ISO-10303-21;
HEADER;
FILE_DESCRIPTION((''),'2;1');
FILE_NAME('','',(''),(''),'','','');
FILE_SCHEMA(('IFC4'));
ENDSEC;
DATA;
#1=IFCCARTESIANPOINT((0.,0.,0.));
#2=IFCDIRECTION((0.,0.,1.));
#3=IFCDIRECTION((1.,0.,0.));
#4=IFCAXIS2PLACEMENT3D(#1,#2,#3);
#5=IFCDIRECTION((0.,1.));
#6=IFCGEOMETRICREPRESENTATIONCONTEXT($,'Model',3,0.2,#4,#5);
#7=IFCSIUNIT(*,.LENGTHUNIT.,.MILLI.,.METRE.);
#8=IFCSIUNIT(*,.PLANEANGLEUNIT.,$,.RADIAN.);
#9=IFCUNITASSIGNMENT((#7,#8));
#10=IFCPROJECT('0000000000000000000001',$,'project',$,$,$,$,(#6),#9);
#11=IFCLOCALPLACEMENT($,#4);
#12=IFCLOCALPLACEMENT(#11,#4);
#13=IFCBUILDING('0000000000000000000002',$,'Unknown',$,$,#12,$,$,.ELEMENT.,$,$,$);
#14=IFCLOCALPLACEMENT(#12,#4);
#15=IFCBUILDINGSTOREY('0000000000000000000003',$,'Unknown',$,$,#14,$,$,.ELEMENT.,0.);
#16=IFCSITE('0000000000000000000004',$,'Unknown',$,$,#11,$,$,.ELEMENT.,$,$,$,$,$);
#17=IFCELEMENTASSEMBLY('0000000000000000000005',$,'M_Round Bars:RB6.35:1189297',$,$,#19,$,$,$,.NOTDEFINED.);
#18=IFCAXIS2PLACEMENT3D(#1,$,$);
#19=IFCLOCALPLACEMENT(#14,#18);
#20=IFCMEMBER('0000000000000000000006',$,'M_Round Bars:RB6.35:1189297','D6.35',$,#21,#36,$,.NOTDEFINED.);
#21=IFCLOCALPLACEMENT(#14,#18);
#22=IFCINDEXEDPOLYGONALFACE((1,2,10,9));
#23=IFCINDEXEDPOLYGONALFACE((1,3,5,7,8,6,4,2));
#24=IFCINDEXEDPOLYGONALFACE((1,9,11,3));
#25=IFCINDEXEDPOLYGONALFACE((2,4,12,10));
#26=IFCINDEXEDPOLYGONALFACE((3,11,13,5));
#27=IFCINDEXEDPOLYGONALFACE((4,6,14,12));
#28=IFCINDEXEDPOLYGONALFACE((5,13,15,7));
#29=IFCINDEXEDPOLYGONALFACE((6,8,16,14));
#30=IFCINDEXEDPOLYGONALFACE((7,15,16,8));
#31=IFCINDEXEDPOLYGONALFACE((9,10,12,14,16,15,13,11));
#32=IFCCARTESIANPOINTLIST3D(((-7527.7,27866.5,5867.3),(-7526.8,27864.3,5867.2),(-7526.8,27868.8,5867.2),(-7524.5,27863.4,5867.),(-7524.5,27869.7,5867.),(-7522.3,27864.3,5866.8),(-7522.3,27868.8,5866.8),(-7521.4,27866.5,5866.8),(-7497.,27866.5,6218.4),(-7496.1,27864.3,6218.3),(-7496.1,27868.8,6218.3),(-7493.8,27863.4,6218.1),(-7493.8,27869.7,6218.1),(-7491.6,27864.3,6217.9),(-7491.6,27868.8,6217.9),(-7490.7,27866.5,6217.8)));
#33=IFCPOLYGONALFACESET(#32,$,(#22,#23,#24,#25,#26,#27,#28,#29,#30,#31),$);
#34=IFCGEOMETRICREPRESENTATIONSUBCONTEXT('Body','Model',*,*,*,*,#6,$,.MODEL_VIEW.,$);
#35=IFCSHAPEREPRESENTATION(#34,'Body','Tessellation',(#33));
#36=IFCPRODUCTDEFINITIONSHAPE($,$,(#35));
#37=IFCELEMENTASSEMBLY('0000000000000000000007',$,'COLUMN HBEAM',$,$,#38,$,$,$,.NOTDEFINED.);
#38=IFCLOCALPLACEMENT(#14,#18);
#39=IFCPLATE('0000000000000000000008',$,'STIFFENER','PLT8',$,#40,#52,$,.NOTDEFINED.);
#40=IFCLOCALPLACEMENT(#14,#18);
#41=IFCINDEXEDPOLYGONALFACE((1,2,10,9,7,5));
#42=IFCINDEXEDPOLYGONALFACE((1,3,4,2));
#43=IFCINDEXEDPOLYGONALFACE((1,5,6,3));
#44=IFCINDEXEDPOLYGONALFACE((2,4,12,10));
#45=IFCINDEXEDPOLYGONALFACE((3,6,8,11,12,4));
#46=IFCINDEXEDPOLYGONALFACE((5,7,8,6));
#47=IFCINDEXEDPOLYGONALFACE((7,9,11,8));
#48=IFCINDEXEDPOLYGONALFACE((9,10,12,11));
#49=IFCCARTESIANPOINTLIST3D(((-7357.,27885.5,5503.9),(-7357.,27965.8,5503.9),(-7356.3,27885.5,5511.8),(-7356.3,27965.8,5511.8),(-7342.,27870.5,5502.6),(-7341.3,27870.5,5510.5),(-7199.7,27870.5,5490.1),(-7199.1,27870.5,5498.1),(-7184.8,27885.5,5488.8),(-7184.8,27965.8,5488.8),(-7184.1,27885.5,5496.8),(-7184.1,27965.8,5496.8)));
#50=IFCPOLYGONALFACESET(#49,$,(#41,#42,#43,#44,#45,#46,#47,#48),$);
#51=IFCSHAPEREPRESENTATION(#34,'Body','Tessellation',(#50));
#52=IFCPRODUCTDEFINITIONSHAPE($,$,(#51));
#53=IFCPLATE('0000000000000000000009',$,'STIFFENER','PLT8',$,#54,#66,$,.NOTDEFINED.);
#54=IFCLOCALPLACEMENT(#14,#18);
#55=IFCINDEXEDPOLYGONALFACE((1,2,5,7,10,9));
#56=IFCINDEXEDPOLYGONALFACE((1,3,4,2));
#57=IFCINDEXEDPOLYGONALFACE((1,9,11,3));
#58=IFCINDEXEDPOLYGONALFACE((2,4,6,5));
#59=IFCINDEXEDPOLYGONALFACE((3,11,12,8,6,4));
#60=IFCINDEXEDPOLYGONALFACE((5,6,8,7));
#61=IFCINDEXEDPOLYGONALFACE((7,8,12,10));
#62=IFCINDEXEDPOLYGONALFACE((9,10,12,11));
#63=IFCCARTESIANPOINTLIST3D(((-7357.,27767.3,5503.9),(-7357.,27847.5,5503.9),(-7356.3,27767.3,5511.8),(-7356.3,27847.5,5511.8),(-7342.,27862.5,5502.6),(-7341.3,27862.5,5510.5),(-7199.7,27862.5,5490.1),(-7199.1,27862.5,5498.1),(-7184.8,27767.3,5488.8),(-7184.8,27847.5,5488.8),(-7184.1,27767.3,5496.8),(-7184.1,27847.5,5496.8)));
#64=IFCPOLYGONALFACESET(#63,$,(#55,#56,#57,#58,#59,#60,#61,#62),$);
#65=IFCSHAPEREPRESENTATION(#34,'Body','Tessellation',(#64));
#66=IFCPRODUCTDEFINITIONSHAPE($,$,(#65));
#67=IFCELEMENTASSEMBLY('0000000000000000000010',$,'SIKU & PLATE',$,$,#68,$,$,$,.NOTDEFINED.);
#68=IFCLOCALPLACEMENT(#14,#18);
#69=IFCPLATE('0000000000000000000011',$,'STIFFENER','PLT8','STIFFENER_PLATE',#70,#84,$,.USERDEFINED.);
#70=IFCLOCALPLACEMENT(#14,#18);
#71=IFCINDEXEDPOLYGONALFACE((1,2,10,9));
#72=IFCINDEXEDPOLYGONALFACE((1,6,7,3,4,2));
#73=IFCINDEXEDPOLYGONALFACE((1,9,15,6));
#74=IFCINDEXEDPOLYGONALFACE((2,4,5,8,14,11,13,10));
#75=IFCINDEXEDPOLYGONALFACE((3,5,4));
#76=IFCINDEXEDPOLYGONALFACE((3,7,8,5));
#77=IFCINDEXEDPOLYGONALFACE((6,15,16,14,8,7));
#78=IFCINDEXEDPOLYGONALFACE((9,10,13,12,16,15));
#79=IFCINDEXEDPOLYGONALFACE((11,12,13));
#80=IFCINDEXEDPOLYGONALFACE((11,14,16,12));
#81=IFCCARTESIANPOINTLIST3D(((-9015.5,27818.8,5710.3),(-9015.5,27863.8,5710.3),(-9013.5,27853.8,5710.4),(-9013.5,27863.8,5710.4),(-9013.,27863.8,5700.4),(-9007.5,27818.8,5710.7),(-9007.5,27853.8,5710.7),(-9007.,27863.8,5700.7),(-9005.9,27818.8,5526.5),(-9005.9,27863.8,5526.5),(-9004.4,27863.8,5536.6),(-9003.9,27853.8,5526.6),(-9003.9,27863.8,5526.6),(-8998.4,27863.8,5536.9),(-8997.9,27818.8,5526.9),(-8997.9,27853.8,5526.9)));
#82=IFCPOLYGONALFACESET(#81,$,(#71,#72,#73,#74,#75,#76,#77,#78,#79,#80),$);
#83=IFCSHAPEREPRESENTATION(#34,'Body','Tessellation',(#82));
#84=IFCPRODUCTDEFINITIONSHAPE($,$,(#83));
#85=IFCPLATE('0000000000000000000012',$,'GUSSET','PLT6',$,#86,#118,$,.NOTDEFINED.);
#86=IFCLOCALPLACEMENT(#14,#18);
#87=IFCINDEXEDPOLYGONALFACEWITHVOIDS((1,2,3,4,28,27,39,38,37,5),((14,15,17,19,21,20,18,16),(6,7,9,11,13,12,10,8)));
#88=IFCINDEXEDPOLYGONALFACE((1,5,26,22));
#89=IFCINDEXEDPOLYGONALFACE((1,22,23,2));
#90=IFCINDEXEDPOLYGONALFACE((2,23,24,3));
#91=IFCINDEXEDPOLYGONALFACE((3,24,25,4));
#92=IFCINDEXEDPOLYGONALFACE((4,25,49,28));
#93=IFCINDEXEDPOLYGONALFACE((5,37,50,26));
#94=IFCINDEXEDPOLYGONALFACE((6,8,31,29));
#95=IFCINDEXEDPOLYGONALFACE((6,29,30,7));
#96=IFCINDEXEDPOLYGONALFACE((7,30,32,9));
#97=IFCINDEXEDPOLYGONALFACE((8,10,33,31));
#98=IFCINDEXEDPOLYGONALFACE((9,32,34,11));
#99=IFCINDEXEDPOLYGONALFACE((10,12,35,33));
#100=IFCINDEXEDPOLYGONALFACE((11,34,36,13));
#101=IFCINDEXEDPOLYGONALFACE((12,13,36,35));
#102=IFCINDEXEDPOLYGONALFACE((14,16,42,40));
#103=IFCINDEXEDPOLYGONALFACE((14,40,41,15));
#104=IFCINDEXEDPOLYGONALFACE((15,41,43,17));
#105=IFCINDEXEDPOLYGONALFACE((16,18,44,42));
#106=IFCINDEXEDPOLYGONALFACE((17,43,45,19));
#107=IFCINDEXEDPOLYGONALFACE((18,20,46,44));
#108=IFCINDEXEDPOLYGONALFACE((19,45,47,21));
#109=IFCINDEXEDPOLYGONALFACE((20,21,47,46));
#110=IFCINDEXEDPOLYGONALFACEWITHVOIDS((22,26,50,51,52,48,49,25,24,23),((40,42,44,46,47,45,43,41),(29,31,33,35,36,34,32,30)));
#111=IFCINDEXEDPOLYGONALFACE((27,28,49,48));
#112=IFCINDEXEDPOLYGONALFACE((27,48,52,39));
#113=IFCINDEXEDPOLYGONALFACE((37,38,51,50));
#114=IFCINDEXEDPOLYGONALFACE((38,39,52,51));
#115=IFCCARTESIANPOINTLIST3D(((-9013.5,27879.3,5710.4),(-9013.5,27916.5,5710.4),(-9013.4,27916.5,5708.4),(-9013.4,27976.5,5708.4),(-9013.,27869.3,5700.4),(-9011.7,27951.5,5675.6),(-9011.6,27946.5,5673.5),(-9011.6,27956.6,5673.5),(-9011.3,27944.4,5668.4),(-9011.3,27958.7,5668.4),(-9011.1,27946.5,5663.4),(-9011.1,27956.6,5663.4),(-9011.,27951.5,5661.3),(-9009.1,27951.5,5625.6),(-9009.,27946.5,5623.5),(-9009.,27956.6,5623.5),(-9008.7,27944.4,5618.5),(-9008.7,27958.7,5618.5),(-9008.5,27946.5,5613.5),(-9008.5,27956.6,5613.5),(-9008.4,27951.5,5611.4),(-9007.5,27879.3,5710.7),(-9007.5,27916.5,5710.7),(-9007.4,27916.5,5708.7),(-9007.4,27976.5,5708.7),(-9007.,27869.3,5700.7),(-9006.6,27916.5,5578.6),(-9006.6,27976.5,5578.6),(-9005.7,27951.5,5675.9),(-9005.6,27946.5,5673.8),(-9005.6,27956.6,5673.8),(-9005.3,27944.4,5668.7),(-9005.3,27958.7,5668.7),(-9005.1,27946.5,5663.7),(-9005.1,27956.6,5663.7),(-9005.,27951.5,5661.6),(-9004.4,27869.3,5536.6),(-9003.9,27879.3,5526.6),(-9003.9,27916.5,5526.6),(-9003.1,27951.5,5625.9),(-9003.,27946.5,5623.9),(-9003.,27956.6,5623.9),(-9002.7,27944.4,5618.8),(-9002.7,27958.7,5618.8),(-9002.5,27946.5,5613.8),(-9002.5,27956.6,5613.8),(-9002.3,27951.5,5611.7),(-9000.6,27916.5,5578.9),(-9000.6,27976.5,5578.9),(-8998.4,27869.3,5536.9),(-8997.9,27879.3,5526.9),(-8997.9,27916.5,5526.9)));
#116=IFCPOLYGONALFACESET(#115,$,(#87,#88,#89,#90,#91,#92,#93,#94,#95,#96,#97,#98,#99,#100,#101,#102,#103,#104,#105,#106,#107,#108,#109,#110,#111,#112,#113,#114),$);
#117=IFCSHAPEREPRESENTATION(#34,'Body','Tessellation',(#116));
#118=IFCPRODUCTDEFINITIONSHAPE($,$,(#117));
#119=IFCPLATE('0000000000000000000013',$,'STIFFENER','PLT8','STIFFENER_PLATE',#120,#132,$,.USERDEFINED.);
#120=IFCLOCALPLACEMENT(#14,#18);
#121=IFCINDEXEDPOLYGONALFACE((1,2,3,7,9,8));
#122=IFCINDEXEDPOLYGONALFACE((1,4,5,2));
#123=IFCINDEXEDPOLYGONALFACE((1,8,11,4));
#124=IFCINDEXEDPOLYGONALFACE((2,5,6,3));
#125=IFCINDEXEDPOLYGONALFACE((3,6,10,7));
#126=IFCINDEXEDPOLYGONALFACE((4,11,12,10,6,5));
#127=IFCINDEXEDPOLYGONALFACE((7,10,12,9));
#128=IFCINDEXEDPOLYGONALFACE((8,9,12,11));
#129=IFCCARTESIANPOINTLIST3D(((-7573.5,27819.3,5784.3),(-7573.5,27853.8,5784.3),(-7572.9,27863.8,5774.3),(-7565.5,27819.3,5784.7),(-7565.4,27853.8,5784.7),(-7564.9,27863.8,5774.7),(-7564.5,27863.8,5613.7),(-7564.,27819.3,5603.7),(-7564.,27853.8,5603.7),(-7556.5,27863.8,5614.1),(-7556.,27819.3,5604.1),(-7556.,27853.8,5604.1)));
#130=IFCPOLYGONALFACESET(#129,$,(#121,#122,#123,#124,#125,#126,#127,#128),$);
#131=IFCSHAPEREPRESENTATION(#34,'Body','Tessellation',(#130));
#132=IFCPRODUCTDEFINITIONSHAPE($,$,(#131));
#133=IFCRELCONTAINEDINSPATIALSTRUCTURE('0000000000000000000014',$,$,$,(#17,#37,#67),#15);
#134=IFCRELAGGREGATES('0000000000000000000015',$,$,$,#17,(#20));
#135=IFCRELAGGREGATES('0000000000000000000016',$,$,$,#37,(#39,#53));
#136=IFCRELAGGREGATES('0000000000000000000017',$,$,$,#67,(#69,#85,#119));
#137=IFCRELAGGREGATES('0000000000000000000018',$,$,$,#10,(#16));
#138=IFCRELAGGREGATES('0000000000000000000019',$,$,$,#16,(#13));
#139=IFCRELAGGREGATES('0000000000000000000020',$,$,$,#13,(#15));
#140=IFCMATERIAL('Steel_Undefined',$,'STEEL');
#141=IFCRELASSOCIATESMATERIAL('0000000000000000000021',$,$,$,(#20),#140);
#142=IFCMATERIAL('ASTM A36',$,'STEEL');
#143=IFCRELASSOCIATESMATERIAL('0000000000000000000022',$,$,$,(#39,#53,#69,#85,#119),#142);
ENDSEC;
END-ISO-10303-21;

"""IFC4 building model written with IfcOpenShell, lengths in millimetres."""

from ifc_helpers import new_model, si_unit, direction, frame, origin_with_axes, place, context, subcontext, project, spatial, line, indexed_curve, outline, extrude, material, element, aggregate, save


model = new_model("IFC4")

# Units and contexts
model_context = context("Model", 3, precision=0.2, world=origin_with_axes(), true_north=direction((0.0, 1.0)))
body_context = subcontext(model_context, "Body", "Model", "MODEL_VIEW")
ifc_project = project(units=[si_unit("LENGTHUNIT", "METRE", prefix="MILLI"), si_unit("PLANEANGLEUNIT", "RADIAN")], contexts=[model_context])

# Site, building, storey
site_placement = place(None, origin_with_axes())
site = spatial("IfcSite", under=ifc_project, at=site_placement, Name="Unknown", CompositionType="ELEMENT")
building_placement = place(site_placement, origin_with_axes())
building = spatial("IfcBuilding", under=site, at=building_placement, Name="Unknown", CompositionType="ELEMENT")
storey_placement = place(building_placement, origin_with_axes())
storey = spatial("IfcBuildingStorey", under=building, at=storey_placement, Name="Unknown", CompositionType="ELEMENT", Elevation=0.0)

# Element assembly, member
ifc_material_1 = material(Name="Steel_Undefined", Category="STEEL")
assembly_1_placement = place(storey_placement, frame((-7493.8, 27866.5, 6218.1), z_axis=(-0.000002, -1.0, 0.0), x_axis=(-0.087153, 0.0, -0.996195)))
assembly_1 = element("IfcElementAssembly", 1, at=assembly_1_placement, inside=storey, Name="M_Round Bars:RB6.35:1189297", PredefinedType="NOTDEFINED")
member_1_placement = place(assembly_1_placement, origin_with_axes())
member_1 = element("IfcMember", 2, at=member_1_placement, material=ifc_material_1, Name="M_Round Bars:RB6.35:1189297", Description="D6.35", PredefinedType="NOTDEFINED", context=body_context, shape_type="SolidModel", body=[
    extrude(outline(indexed_curve([(3.2, 0.0), (2.2, 2.2), (0.0, 3.2), (-2.2, 2.2), (-3.2, 0.0), (-2.2, -2.2), (0.0, -3.2), (2.2, -2.2)], segments=[line(1, 2, 3, 4, 5, 6, 7, 8, 1)])), frame((0.0, 0.0, 0.0), z_axis=(-1.0, 0.0, 0.0), x_axis=(0.0, 0.0, 1.0)), (0.0, 0.0, -1.0), 352.4),
])
aggregate(assembly_1, [member_1])

# Element assemblies, plates, voiding features
assembly_2_placement = place(storey_placement, frame((-7668.5, 27866.5, 952.0), z_axis=(0.0, -1.0, 0.0), x_axis=(0.087153, 0.0, 0.996195)))
assembly_2 = element("IfcElementAssembly", 3, at=assembly_2_placement, inside=storey, Name="COLUMN HBEAM", PredefinedType="NOTDEFINED")
ifc_material_2 = material(Name="ASTM A36", Category="STEEL")
plate_1_placement = place(assembly_2_placement, frame((4565.7, 86.4, -4.0), z_axis=(-1.0, 0.0, 0.0), x_axis=(0.0, 0.0, -1.0)))
plate_1 = element("IfcPlate", 4, at=plate_1_placement, material=ifc_material_2, Name="STIFFENER", Description="PLT8", PredefinedType="NOTDEFINED", context=body_context, shape_type="SolidModel", body=[
    extrude(outline(indexed_curve([(0.0, 0.0), (95.2, 0.0), (95.2, 172.8), (0.0, 172.8)], segments=[line(1, 2, 3, 4, 1)])), frame((0.0, 0.0, 4.0), z_axis=(0.0, 0.0, 1.0), x_axis=(1.0, 0.0, 0.0)), (0.0, 0.0, -1.0), 8.0),
])
voiding_feature_1_placement = place(plate_1_placement, frame((0.0, 157.8, 0.0), z_axis=(0.0, 0.0, 1.0), x_axis=(0.707107, 0.707107, 0.0)))
element("IfcVoidingFeature", 5, at=voiding_feature_1_placement, cuts=plate_1, Name="SLAB", PredefinedType="HOLE", context=body_context, shape_type="SolidModel", body=[
    extrude(outline(indexed_curve([(0.0, 0.0), (21.2, 0.0), (10.6, 10.6)], segments=[line(1, 2, 3, 1)])), frame((0.0, 0.0, 4.0), z_axis=(0.0, 0.0, 1.0), x_axis=(1.0, 0.0, 0.0)), (0.0, 0.0, -1.0), 8.0),
])
voiding_feature_2_placement = place(plate_1_placement, origin_with_axes())
element("IfcVoidingFeature", 6, at=voiding_feature_2_placement, cuts=plate_1, Name="SLAB", PredefinedType="HOLE", context=body_context, shape_type="SolidModel", body=[
    extrude(outline(indexed_curve([(0.0, 0.0), (15.0, 0.0), (0.0, 15.0)], segments=[line(1, 2, 3, 1)])), frame((0.0, 0.0, 4.0), z_axis=(0.0, 0.0, 1.0), x_axis=(1.0, 0.0, 0.0)), (0.0, 0.0, -1.0), 8.0),
])
plate_2_placement = place(assembly_2_placement, frame((4565.7, 86.4, 99.2), z_axis=(-1.0, 0.0, 0.0), x_axis=(0.0, 0.0, -1.0)))
plate_2 = element("IfcPlate", 7, at=plate_2_placement, material=ifc_material_2, Name="STIFFENER", Description="PLT8", PredefinedType="NOTDEFINED", context=body_context, shape_type="SolidModel", body=[
    extrude(outline(indexed_curve([(0.0, 0.0), (95.2, 0.0), (95.2, 172.8), (0.0, 172.8)], segments=[line(1, 2, 3, 4, 1)])), frame((0.0, 0.0, 4.0), z_axis=(0.0, 0.0, 1.0), x_axis=(1.0, 0.0, 0.0)), (0.0, 0.0, -1.0), 8.0),
])
voiding_feature_3_placement = place(plate_2_placement, frame((80.2, 172.8, 0.0), z_axis=(0.0, 0.0, 1.0), x_axis=(0.707107, -0.707107, 0.0)))
element("IfcVoidingFeature", 8, at=voiding_feature_3_placement, cuts=plate_2, Name="SLAB", PredefinedType="HOLE", context=body_context, shape_type="SolidModel", body=[
    extrude(outline(indexed_curve([(0.0, 0.0), (21.2, 0.0), (10.6, 10.6)], segments=[line(1, 2, 3, 1)])), frame((0.0, 0.0, 4.0), z_axis=(0.0, 0.0, 1.0), x_axis=(1.0, 0.0, 0.0)), (0.0, 0.0, -1.0), 8.0),
])
voiding_feature_4_placement = place(plate_2_placement, frame((80.2, 0.0, 0.0), z_axis=(0.0, 0.0, 1.0), x_axis=(1.0, 0.0, 0.0)))
element("IfcVoidingFeature", 9, at=voiding_feature_4_placement, cuts=plate_2, Name="SLAB", PredefinedType="HOLE", context=body_context, shape_type="SolidModel", body=[
    extrude(outline(indexed_curve([(0.0, 0.0), (15.0, 0.0), (15.0, 15.0)], segments=[line(1, 2, 3, 1)])), frame((0.0, 0.0, 4.0), z_axis=(0.0, 0.0, 1.0), x_axis=(1.0, 0.0, 0.0)), (0.0, 0.0, -1.0), 8.0),
])
aggregate(assembly_2, [plate_1, plate_2])
assembly_3_placement = place(storey_placement, frame((-12370.2, 27766.5, 5616.6), z_axis=(-0.052336, 0.0, 0.99863), x_axis=(0.99863, 0.0, 0.052336)))
assembly_3 = element("IfcElementAssembly", 10, at=assembly_3_placement, inside=storey, Name="SIKU & PLATE", PredefinedType="NOTDEFINED")
plate_3_placement = place(assembly_3_placement, frame((3359.0, 97.3, -266.0), z_axis=(-1.0, 0.0, 0.0), x_axis=(0.0, -1.0, 0.0)))
plate_3 = element("IfcPlate", 11, at=plate_3_placement, material=ifc_material_2, Name="STIFFENER", Description="PLT8", ObjectType="STIFFENER_PLATE", PredefinedType="USERDEFINED", context=body_context, shape_type="SolidModel", body=[
    extrude(outline(indexed_curve([(0.0, 0.0), (45.0, 0.0), (45.0, 184.0), (0.0, 184.0)], segments=[line(1, 2, 3, 4, 1)])), frame((0.0, 0.0, 4.0), z_axis=(0.0, 0.0, 1.0), x_axis=(1.0, 0.0, 0.0)), (0.0, 0.0, -1.0), 8.0),
])
voiding_feature_5_placement = place(plate_3_placement, frame((0.0, 174.0, -1.0), z_axis=(0.0, 0.0, 1.0), x_axis=(0.707107, 0.707107, 0.0)))
element("IfcVoidingFeature", 12, at=voiding_feature_5_placement, cuts=plate_3, Name="SLAB", PredefinedType="HOLE", context=body_context, shape_type="SolidModel", body=[
    extrude(outline(indexed_curve([(0.0, 0.0), (14.1, 0.0), (7.1, 7.1)], segments=[line(1, 2, 3, 1)])), frame((0.0, 0.0, 3.0), z_axis=(0.0, 0.0, 1.0), x_axis=(1.0, 0.0, 0.0)), (0.0, 0.0, -1.0), 6.0),
])
voiding_feature_6_placement = place(plate_3_placement, frame((0.0, 0.0, -1.0), z_axis=(0.0, 0.0, 1.0), x_axis=(1.0, 0.0, 0.0)))
element("IfcVoidingFeature", 13, at=voiding_feature_6_placement, cuts=plate_3, Name="SLAB", PredefinedType="HOLE", context=body_context, shape_type="SolidModel", body=[
    extrude(outline(indexed_curve([(0.0, 0.0), (10.0, 0.0), (0.0, 10.0)], segments=[line(1, 2, 3, 1)])), frame((0.0, 0.0, 3.0), z_axis=(0.0, 0.0, 1.0), x_axis=(1.0, 0.0, 0.0)), (0.0, 0.0, -1.0), 6.0),
])
plate_4_placement = place(assembly_3_placement, frame((3360.0, 102.8, -82.0), z_axis=(-1.0, 0.0, 0.0), x_axis=(0.0, 1.0, 0.0)))
plate_4 = element("IfcPlate", 14, at=plate_4_placement, material=ifc_material_2, Name="GUSSET", Description="PLT6", PredefinedType="NOTDEFINED", context=body_context, shape_type="SolidModel", body=[
    extrude(outline(indexed_curve([(0.0, 0.0), (47.2, 0.0), (47.2, 2.0), (107.3, 2.0), (107.3, 132.0), (47.2, 132.0), (47.2, 184.0), (0.0, 184.0)], segments=[line(1, 2, 3, 4, 5, 6, 7, 8, 1)])), frame((0.0, 0.0, 3.0), z_axis=(0.0, 0.0, 1.0), x_axis=(1.0, 0.0, 0.0)), (0.0, 0.0, -1.0), 6.0),
])
voiding_feature_7_placement = place(plate_4_placement, frame((10.0, 0.0, 0.0), z_axis=(0.0, 0.0, 1.0), x_axis=(-0.707107, 0.707107, 0.0)))
element("IfcVoidingFeature", 15, at=voiding_feature_7_placement, cuts=plate_4, Name="SLAB", PredefinedType="HOLE", context=body_context, shape_type="SolidModel", body=[
    extrude(outline(indexed_curve([(0.0, 0.0), (14.1, 0.0), (7.1, 7.1)], segments=[line(1, 2, 3, 1)])), frame((0.0, 0.0, 3.0), z_axis=(0.0, 0.0, 1.0), x_axis=(1.0, 0.0, 0.0)), (0.0, 0.0, -1.0), 6.0),
])
voiding_feature_8_placement = place(plate_4_placement, frame((0.0, 174.0, 0.0), z_axis=(0.0, 0.0, 1.0), x_axis=(0.707107, 0.707107, 0.0)))
element("IfcVoidingFeature", 16, at=voiding_feature_8_placement, cuts=plate_4, Name="SLAB", PredefinedType="HOLE", context=body_context, shape_type="SolidModel", body=[
    extrude(outline(indexed_curve([(0.0, 0.0), (14.1, 0.0), (7.1, 7.1)], segments=[line(1, 2, 3, 1)])), frame((0.0, 0.0, 3.0), z_axis=(0.0, 0.0, 1.0), x_axis=(1.0, 0.0, 0.0)), (0.0, 0.0, -1.0), 6.0),
])
voiding_feature_9_placement = place(plate_4_placement, frame((82.3, 92.0, -3.5), z_axis=(-1.0, 0.0, 0.0), x_axis=(0.0, 0.0, 1.0)))
element("IfcVoidingFeature", 17, at=voiding_feature_9_placement, cuts=plate_4, Name="BEAM", PredefinedType="HOLE", context=body_context, shape_type="SolidModel", body=[
    extrude(outline(indexed_curve([(7.1, 0.0), (5.1, 5.1), (0.0, 7.1), (-5.1, 5.1), (-7.1, 0.0), (-5.1, -5.1), (0.0, -7.1), (5.1, -5.1)], segments=[line(1, 2, 3, 4, 5, 6, 7, 8, 1)])), frame((0.0, 0.0, 0.0), z_axis=(-1.0, 0.0, 0.0), x_axis=(0.0, 0.0, 1.0)), (0.0, 0.0, -1.0), 7.0),
])
voiding_feature_10_placement = place(plate_4_placement, frame((82.3, 42.0, -3.5), z_axis=(-1.0, 0.0, 0.0), x_axis=(0.0, 0.0, 1.0)))
element("IfcVoidingFeature", 18, at=voiding_feature_10_placement, cuts=plate_4, Name="BEAM", PredefinedType="HOLE", context=body_context, shape_type="SolidModel", body=[
    extrude(outline(indexed_curve([(7.1, 0.0), (5.1, 5.1), (0.0, 7.1), (-5.1, 5.1), (-7.1, 0.0), (-5.1, -5.1), (0.0, -7.1), (5.1, -5.1)], segments=[line(1, 2, 3, 4, 5, 6, 7, 8, 1)])), frame((0.0, 0.0, 0.0), z_axis=(-1.0, 0.0, 0.0), x_axis=(0.0, 0.0, 1.0)), (0.0, 0.0, -1.0), 7.0),
])
plate_5_placement = place(assembly_3_placement, frame((4803.0, 97.3, -264.4), z_axis=(-1.0, 0.0, 0.0), x_axis=(0.0, -1.0, 0.0)))
plate_5 = element("IfcPlate", 19, at=plate_5_placement, material=ifc_material_2, Name="STIFFENER", Description="PLT8", ObjectType="STIFFENER_PLATE", PredefinedType="USERDEFINED", context=body_context, shape_type="SolidModel", body=[
    extrude(outline(indexed_curve([(0.0, 0.0), (44.5, 0.0), (44.5, 180.8), (0.0, 180.8)], segments=[line(1, 2, 3, 4, 1)])), frame((0.0, 0.0, 4.0), z_axis=(0.0, 0.0, 1.0), x_axis=(1.0, 0.0, 0.0)), (0.0, 0.0, -1.0), 8.0),
])
voiding_feature_11_placement = place(plate_5_placement, frame((0.0, 170.8, 0.0), z_axis=(0.0, 0.0, 1.0), x_axis=(0.707107, 0.707107, 0.0)))
element("IfcVoidingFeature", 20, at=voiding_feature_11_placement, cuts=plate_5, Name="SLAB", PredefinedType="HOLE", context=body_context, shape_type="SolidModel", body=[
    extrude(outline(indexed_curve([(0.0, 0.0), (14.1, 0.0), (7.1, 7.1)], segments=[line(1, 2, 3, 1)])), frame((0.0, 0.0, 4.0), z_axis=(0.0, 0.0, 1.0), x_axis=(1.0, 0.0, 0.0)), (0.0, 0.0, -1.0), 8.0),
])
voiding_feature_12_placement = place(plate_5_placement, frame((10.0, 0.0, 0.0), z_axis=(0.0, 0.0, 1.0), x_axis=(-0.707107, 0.707107, 0.0)))
element("IfcVoidingFeature", 21, at=voiding_feature_12_placement, cuts=plate_5, Name="SLAB", PredefinedType="HOLE", context=body_context, shape_type="SolidModel", body=[
    extrude(outline(indexed_curve([(0.0, 0.0), (14.1, 0.0), (7.1, 7.1)], segments=[line(1, 2, 3, 1)])), frame((0.0, 0.0, 4.0), z_axis=(0.0, 0.0, 1.0), x_axis=(1.0, 0.0, 0.0)), (0.0, 0.0, -1.0), 8.0),
])
aggregate(assembly_3, [plate_3, plate_4, plate_5])

save(model, "model.ifc")
